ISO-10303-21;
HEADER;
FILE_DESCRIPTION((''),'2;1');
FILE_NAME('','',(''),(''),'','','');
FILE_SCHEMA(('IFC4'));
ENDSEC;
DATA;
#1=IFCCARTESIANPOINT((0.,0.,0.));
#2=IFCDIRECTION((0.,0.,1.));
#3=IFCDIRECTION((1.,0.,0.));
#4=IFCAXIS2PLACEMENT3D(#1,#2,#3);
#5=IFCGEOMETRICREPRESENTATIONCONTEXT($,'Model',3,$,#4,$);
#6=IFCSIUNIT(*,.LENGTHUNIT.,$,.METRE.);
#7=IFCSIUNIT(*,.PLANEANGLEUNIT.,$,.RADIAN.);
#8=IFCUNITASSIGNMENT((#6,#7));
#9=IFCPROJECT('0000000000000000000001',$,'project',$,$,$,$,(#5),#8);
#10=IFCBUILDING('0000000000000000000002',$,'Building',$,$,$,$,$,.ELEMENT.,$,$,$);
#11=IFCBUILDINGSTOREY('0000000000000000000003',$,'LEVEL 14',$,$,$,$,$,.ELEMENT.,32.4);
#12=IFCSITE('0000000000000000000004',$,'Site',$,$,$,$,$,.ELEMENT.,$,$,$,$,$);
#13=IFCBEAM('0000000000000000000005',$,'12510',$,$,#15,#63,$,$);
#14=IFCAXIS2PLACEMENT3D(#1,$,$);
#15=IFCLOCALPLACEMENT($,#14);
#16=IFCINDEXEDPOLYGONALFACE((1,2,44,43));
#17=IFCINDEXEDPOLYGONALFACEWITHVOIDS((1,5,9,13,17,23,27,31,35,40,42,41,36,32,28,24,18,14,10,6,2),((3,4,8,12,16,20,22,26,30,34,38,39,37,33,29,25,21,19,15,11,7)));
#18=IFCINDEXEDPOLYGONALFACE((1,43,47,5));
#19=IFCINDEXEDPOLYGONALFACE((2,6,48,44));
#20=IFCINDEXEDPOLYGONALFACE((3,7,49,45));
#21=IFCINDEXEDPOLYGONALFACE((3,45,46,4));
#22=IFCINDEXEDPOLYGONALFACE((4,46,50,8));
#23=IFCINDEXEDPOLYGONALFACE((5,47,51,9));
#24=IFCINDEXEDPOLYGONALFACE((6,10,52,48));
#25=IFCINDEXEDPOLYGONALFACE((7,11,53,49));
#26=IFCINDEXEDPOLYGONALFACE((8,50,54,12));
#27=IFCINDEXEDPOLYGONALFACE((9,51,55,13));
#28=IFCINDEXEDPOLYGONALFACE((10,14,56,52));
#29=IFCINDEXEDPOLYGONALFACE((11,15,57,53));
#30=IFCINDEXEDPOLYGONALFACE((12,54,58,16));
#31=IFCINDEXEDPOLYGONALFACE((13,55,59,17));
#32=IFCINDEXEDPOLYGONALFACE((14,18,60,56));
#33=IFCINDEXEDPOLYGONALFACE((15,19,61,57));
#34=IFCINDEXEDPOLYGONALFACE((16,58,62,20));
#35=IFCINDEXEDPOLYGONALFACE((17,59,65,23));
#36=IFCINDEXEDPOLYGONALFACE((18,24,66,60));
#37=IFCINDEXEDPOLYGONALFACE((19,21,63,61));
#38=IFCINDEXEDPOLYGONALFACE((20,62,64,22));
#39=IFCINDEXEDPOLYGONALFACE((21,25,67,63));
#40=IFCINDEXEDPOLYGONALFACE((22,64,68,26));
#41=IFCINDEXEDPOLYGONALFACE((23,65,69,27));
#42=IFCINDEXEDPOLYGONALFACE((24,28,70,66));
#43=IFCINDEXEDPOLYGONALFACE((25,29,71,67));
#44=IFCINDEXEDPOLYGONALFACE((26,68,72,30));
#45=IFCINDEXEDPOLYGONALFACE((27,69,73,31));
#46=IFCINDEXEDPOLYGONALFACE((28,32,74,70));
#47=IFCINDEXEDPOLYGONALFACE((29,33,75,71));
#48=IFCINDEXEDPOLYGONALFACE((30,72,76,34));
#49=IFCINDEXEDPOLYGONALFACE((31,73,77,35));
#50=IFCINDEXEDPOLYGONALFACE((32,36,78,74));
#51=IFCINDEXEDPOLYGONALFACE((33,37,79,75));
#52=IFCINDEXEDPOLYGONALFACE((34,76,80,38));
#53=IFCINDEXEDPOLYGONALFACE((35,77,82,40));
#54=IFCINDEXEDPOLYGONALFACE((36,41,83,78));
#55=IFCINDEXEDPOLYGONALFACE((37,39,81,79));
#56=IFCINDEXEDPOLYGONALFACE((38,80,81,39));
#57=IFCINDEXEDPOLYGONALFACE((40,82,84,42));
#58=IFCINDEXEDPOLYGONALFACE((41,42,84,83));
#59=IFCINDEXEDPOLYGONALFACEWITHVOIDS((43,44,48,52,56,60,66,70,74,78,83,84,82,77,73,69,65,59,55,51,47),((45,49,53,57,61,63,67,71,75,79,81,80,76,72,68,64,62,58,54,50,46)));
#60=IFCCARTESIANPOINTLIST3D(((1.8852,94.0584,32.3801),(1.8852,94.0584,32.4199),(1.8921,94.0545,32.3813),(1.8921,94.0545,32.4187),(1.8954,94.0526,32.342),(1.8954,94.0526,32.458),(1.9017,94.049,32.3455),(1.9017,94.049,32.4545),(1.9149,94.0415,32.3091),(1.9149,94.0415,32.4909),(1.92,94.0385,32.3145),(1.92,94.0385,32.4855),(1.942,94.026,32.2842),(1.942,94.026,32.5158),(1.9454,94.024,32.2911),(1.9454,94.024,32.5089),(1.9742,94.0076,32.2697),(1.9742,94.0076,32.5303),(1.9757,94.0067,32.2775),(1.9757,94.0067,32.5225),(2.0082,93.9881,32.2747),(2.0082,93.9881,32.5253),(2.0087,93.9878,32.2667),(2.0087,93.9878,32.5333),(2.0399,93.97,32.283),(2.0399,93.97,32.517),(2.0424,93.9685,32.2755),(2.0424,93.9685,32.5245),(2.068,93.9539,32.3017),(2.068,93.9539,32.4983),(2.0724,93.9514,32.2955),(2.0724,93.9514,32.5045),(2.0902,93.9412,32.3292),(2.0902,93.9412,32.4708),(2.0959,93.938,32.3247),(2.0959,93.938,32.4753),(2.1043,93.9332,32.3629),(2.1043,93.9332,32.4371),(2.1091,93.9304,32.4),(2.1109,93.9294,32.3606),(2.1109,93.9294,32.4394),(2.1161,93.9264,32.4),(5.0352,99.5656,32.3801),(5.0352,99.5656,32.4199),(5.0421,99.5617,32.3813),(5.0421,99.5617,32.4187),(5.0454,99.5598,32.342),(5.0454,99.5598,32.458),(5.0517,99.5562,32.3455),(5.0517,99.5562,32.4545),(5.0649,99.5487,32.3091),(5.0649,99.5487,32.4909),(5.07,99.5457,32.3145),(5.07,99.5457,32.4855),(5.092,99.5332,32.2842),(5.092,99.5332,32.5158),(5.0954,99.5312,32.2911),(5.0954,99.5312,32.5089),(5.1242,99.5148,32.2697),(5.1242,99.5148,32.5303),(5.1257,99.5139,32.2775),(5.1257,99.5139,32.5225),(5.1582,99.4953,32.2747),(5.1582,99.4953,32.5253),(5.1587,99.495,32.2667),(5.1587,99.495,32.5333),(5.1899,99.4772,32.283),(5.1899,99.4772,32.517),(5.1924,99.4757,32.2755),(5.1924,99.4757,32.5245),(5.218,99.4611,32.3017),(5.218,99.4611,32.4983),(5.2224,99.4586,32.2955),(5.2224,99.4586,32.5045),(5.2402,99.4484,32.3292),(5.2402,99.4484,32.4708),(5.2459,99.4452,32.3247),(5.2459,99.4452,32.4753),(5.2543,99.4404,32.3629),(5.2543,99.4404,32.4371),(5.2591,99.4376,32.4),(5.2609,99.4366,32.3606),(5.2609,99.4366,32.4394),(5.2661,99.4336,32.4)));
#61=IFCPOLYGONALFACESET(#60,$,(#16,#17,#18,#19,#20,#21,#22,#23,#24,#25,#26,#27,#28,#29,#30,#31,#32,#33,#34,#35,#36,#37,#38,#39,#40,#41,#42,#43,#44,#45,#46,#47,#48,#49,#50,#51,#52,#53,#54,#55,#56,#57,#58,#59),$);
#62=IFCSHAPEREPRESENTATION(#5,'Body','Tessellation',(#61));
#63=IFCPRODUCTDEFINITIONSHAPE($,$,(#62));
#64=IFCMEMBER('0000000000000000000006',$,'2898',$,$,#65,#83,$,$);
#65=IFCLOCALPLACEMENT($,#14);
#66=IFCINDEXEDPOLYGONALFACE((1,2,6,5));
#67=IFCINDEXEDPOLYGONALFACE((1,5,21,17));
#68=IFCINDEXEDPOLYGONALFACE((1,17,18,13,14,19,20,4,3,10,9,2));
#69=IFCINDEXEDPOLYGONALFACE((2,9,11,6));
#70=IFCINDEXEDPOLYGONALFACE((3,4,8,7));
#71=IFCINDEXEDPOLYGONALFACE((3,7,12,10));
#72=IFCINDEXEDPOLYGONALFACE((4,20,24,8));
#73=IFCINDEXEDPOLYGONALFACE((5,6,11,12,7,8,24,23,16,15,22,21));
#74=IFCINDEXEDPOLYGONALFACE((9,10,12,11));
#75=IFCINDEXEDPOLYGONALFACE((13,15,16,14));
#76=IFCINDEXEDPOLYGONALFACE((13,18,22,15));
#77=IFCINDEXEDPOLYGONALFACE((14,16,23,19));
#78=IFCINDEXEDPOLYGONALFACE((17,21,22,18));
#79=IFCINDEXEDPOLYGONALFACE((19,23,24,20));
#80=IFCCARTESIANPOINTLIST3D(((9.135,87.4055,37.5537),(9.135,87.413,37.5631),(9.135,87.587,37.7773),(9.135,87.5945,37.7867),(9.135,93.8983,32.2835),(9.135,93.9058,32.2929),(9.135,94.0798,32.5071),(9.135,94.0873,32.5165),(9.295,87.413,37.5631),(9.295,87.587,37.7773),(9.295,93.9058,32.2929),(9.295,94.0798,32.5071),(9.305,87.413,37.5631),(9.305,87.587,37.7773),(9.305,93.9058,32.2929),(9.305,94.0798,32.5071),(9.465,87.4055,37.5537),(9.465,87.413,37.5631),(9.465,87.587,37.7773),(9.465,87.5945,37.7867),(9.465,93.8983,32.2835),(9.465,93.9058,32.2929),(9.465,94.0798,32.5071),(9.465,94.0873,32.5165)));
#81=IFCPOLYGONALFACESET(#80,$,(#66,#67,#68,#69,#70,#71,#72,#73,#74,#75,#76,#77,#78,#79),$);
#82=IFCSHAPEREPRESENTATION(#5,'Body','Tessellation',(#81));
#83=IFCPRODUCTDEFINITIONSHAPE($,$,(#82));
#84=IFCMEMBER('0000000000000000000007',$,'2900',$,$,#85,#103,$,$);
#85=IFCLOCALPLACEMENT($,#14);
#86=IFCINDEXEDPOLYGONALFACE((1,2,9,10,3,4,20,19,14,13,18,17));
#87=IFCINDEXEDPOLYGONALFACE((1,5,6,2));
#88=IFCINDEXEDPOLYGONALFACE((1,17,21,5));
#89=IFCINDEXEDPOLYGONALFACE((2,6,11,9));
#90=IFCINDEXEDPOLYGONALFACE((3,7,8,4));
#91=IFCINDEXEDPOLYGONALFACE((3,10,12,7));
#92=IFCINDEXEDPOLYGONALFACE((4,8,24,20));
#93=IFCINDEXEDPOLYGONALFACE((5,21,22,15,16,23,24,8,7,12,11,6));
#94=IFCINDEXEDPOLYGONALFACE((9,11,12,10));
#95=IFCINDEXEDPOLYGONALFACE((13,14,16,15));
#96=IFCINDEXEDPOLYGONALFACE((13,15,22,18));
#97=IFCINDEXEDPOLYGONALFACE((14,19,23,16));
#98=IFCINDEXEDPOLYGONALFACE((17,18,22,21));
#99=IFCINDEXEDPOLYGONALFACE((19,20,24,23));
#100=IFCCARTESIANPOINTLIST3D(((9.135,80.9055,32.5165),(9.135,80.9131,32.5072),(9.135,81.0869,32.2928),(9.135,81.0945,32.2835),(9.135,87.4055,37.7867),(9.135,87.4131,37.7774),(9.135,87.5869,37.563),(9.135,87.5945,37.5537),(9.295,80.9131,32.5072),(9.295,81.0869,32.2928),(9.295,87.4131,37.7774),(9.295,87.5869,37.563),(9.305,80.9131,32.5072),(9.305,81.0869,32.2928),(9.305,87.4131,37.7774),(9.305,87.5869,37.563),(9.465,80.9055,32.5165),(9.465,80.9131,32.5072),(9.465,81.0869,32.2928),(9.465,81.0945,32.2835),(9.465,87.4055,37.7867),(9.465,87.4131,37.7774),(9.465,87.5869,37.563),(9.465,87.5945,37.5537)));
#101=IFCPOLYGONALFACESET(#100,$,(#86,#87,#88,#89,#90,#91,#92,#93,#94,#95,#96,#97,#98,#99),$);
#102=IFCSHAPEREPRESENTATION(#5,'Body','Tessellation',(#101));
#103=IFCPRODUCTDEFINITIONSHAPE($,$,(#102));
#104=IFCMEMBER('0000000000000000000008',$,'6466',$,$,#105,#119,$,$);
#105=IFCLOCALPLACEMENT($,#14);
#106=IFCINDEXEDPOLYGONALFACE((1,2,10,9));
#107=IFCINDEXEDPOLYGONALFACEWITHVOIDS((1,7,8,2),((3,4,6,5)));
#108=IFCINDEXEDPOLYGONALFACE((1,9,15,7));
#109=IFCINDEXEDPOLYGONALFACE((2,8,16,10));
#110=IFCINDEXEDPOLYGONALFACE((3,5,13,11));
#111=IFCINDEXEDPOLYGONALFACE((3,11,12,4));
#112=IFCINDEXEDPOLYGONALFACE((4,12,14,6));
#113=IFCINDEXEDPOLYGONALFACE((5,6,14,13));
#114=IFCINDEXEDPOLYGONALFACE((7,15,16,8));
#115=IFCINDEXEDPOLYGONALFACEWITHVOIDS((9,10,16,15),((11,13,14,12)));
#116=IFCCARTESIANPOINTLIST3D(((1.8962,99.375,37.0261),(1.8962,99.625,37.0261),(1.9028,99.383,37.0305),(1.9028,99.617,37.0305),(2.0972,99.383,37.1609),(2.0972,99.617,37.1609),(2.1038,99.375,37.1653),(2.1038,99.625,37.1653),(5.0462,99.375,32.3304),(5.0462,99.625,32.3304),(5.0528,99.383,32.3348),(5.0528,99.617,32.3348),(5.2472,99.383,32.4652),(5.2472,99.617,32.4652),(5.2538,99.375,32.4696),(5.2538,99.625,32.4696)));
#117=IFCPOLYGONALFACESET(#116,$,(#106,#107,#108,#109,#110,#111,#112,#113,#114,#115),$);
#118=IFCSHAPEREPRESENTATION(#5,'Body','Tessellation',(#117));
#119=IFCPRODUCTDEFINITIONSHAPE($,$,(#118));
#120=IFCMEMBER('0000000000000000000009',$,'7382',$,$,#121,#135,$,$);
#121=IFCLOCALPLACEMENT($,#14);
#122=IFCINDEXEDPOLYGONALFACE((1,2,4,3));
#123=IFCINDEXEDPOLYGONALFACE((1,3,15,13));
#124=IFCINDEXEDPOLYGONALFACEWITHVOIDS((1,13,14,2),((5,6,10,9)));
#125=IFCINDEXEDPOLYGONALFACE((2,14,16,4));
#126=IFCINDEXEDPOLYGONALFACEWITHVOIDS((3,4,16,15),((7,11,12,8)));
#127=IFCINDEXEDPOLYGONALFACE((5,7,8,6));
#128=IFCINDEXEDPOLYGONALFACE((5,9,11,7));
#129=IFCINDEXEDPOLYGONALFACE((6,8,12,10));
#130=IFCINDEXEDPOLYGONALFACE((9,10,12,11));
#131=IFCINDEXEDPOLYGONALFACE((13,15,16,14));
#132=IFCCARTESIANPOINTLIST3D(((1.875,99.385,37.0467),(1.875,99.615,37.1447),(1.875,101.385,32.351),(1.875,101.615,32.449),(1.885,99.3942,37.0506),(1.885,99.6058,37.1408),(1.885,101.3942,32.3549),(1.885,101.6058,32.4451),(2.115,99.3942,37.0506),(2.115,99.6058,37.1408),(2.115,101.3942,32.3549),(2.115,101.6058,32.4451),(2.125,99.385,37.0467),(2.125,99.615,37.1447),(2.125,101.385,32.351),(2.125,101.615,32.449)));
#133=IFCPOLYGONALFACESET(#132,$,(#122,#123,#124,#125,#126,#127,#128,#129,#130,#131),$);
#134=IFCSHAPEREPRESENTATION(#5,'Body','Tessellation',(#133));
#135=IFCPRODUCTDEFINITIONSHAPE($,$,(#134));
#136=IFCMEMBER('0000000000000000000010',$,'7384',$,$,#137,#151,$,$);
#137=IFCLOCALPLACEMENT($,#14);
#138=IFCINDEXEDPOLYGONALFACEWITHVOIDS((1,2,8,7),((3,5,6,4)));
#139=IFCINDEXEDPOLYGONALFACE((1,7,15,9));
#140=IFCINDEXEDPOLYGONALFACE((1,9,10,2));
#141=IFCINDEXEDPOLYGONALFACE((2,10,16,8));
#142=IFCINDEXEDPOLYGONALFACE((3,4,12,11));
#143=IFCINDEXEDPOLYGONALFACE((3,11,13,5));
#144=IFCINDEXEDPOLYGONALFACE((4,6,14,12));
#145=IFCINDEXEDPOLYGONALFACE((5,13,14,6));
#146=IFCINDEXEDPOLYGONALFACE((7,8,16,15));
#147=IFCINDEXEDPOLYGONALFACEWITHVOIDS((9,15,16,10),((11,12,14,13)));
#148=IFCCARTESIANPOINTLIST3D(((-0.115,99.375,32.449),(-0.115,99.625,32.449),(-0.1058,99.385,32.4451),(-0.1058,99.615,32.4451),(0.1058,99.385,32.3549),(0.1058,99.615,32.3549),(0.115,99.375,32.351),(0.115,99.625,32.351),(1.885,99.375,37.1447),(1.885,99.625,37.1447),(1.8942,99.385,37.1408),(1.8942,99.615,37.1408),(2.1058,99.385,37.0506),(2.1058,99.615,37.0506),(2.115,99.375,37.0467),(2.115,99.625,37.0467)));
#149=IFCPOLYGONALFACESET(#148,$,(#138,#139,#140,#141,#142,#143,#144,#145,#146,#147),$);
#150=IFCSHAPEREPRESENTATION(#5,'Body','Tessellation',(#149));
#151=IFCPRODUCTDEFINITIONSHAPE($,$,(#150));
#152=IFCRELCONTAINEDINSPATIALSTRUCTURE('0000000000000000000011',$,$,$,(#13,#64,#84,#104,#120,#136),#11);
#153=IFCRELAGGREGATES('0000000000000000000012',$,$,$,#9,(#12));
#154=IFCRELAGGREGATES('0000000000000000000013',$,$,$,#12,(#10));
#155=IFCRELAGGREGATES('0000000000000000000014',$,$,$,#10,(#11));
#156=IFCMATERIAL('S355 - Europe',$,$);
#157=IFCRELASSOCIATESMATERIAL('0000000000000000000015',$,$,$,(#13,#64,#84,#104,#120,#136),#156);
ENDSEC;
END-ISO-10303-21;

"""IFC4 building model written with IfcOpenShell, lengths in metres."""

from ifc_helpers import new_model, si_unit, frame, origin_with_axes, origin_2d_with_axis, place, context, project, spatial, hollow_rectangle, hollow_circle, i_section, extrude, material, material_profile, profile_set, profile_usage, element, save


model = new_model("IFC4")

# Units and contexts
model_context = context("Model", 3, world=origin_with_axes())
ifc_project = project(units=[si_unit("LENGTHUNIT", "METRE"), si_unit("PLANEANGLEUNIT", "RADIAN")], contexts=[model_context])

# Site, building, storey
site = spatial("IfcSite", under=ifc_project, Name="Site", CompositionType="ELEMENT")
building = spatial("IfcBuilding", under=site, Name="Building", CompositionType="ELEMENT")
storey = spatial("IfcBuildingStorey", under=building, Name="LEVEL 14", CompositionType="ELEMENT", Elevation=32.4)

# Shared definitions
ifc_material = material(Name="S355 - Europe")

# Beam
ifc_material_profile_1 = material_profile(ifc_material, hollow_circle(Radius=0.1337, WallThickness=0.008, at=origin_2d_with_axis()))
ifc_profile_set_1 = profile_set([ifc_material_profile_1])
ifc_profile_usage_1 = profile_usage(ifc_profile_set_1, cardinal=10)
beam_1_placement = place(None, frame((5.15, 99.5, 32.4), z_axis=(-0.496499, -0.868037, 0.0), x_axis=(0.868037, -0.496499, 0.0)))
element("IfcBeam", 1, at=beam_1_placement, inside=storey, material=ifc_profile_usage_1, Name="12510", context=model_context, shape_type="SweptSolid", body=[
    extrude(hollow_circle(Radius=0.1337, WallThickness=0.008, at=origin_2d_with_axis()), origin_with_axes(), (0.0, 0.0, 1.0), 6.3444),
])

# Members
ifc_material_profile_2 = material_profile(ifc_material, i_section(OverallWidth=0.33, OverallDepth=0.3, WebThickness=0.01, FlangeThickness=0.012, at=origin_2d_with_axis()))
ifc_profile_set_2 = profile_set([ifc_material_profile_2])
ifc_profile_usage_2 = profile_usage(ifc_profile_set_2, cardinal=10)
member_1_placement = place(None, frame((9.3, 93.9928, 32.4), z_axis=(0.0, -0.776418, 0.630218), x_axis=(1.0, 0.0, 0.0)))
element("IfcMember", 2, at=member_1_placement, inside=storey, material=ifc_profile_usage_2, Name="2898", context=model_context, shape_type="SweptSolid", body=[
    extrude(i_section(OverallWidth=0.33, OverallDepth=0.3, WebThickness=0.01, FlangeThickness=0.012, at=origin_2d_with_axis()), origin_with_axes(), (0.0, 0.0, 1.0), 8.3625),
])
ifc_material_profile_3 = material_profile(ifc_material, i_section(OverallWidth=0.33, OverallDepth=0.3, WebThickness=0.01, FlangeThickness=0.012, at=origin_2d_with_axis()))
ifc_profile_set_3 = profile_set([ifc_material_profile_3])
ifc_profile_usage_3 = profile_usage(ifc_profile_set_3, cardinal=10)
member_2_placement = place(None, frame((9.3, 87.5, 37.6702), z_axis=(0.0, -0.77676, -0.629797), x_axis=(1.0, 0.0, 0.0)))
element("IfcMember", 3, at=member_2_placement, inside=storey, material=ifc_profile_usage_3, Name="2900", context=model_context, shape_type="SweptSolid", body=[
    extrude(i_section(OverallWidth=0.33, OverallDepth=0.3, WebThickness=0.01, FlangeThickness=0.012, at=origin_2d_with_axis()), origin_with_axes(), (0.0, 0.0, 1.0), 8.3681),
])
ifc_material_profile_4 = material_profile(ifc_material, hollow_rectangle(XDim=0.25, YDim=0.25, WallThickness=0.008, at=origin_2d_with_axis()))
ifc_profile_set_4 = profile_set([ifc_material_profile_4])
ifc_profile_usage_4 = profile_usage(ifc_profile_set_4, cardinal=10)
member_3_placement = place(None, frame((2.0, 99.5, 37.0957), z_axis=(0.55709, 0.0, -0.830452), x_axis=(0.0, 1.0, 0.0)))
element("IfcMember", 4, at=member_3_placement, inside=storey, material=ifc_profile_usage_4, Name="6466", context=model_context, shape_type="SweptSolid", body=[
    extrude(hollow_rectangle(XDim=0.25, YDim=0.25, WallThickness=0.008, at=origin_2d_with_axis()), origin_with_axes(), (0.0, 0.0, 1.0), 5.6544),
])
ifc_material_profile_5 = material_profile(ifc_material, hollow_rectangle(XDim=0.25, YDim=0.25, WallThickness=0.01, at=origin_2d_with_axis()))
ifc_profile_set_5 = profile_set([ifc_material_profile_5])
ifc_profile_usage_5 = profile_usage(ifc_profile_set_5, cardinal=10)
member_4_placement = place(None, frame((2.0, 99.5, 37.0957), z_axis=(0.0, 0.391859, -0.920025), x_axis=(-1.0, 0.0, 0.0)))
element("IfcMember", 5, at=member_4_placement, inside=storey, material=ifc_profile_usage_5, Name="7382", context=model_context, shape_type="SweptSolid", body=[
    extrude(hollow_rectangle(XDim=0.25, YDim=0.25, WallThickness=0.01, at=origin_2d_with_axis()), origin_with_axes(), (0.0, 0.0, 1.0), 5.1039),
])
ifc_material_profile_6 = material_profile(ifc_material, hollow_rectangle(XDim=0.25, YDim=0.25, WallThickness=0.01, at=origin_2d_with_axis()))
ifc_profile_set_6 = profile_set([ifc_material_profile_6])
ifc_profile_usage_6 = profile_usage(ifc_profile_set_6, cardinal=10)
member_5_placement = place(None, frame((2.0, 99.5, 37.0957), z_axis=(-0.391859, 0.0, -0.920025), x_axis=(0.0, -1.0, 0.0)))
element("IfcMember", 6, at=member_5_placement, inside=storey, material=ifc_profile_usage_6, Name="7384", context=model_context, shape_type="SweptSolid", body=[
    extrude(hollow_rectangle(XDim=0.25, YDim=0.25, WallThickness=0.01, at=origin_2d_with_axis()), origin_with_axes(), (0.0, 0.0, 1.0), 5.1039),
])

save(model, "model.ifc")
